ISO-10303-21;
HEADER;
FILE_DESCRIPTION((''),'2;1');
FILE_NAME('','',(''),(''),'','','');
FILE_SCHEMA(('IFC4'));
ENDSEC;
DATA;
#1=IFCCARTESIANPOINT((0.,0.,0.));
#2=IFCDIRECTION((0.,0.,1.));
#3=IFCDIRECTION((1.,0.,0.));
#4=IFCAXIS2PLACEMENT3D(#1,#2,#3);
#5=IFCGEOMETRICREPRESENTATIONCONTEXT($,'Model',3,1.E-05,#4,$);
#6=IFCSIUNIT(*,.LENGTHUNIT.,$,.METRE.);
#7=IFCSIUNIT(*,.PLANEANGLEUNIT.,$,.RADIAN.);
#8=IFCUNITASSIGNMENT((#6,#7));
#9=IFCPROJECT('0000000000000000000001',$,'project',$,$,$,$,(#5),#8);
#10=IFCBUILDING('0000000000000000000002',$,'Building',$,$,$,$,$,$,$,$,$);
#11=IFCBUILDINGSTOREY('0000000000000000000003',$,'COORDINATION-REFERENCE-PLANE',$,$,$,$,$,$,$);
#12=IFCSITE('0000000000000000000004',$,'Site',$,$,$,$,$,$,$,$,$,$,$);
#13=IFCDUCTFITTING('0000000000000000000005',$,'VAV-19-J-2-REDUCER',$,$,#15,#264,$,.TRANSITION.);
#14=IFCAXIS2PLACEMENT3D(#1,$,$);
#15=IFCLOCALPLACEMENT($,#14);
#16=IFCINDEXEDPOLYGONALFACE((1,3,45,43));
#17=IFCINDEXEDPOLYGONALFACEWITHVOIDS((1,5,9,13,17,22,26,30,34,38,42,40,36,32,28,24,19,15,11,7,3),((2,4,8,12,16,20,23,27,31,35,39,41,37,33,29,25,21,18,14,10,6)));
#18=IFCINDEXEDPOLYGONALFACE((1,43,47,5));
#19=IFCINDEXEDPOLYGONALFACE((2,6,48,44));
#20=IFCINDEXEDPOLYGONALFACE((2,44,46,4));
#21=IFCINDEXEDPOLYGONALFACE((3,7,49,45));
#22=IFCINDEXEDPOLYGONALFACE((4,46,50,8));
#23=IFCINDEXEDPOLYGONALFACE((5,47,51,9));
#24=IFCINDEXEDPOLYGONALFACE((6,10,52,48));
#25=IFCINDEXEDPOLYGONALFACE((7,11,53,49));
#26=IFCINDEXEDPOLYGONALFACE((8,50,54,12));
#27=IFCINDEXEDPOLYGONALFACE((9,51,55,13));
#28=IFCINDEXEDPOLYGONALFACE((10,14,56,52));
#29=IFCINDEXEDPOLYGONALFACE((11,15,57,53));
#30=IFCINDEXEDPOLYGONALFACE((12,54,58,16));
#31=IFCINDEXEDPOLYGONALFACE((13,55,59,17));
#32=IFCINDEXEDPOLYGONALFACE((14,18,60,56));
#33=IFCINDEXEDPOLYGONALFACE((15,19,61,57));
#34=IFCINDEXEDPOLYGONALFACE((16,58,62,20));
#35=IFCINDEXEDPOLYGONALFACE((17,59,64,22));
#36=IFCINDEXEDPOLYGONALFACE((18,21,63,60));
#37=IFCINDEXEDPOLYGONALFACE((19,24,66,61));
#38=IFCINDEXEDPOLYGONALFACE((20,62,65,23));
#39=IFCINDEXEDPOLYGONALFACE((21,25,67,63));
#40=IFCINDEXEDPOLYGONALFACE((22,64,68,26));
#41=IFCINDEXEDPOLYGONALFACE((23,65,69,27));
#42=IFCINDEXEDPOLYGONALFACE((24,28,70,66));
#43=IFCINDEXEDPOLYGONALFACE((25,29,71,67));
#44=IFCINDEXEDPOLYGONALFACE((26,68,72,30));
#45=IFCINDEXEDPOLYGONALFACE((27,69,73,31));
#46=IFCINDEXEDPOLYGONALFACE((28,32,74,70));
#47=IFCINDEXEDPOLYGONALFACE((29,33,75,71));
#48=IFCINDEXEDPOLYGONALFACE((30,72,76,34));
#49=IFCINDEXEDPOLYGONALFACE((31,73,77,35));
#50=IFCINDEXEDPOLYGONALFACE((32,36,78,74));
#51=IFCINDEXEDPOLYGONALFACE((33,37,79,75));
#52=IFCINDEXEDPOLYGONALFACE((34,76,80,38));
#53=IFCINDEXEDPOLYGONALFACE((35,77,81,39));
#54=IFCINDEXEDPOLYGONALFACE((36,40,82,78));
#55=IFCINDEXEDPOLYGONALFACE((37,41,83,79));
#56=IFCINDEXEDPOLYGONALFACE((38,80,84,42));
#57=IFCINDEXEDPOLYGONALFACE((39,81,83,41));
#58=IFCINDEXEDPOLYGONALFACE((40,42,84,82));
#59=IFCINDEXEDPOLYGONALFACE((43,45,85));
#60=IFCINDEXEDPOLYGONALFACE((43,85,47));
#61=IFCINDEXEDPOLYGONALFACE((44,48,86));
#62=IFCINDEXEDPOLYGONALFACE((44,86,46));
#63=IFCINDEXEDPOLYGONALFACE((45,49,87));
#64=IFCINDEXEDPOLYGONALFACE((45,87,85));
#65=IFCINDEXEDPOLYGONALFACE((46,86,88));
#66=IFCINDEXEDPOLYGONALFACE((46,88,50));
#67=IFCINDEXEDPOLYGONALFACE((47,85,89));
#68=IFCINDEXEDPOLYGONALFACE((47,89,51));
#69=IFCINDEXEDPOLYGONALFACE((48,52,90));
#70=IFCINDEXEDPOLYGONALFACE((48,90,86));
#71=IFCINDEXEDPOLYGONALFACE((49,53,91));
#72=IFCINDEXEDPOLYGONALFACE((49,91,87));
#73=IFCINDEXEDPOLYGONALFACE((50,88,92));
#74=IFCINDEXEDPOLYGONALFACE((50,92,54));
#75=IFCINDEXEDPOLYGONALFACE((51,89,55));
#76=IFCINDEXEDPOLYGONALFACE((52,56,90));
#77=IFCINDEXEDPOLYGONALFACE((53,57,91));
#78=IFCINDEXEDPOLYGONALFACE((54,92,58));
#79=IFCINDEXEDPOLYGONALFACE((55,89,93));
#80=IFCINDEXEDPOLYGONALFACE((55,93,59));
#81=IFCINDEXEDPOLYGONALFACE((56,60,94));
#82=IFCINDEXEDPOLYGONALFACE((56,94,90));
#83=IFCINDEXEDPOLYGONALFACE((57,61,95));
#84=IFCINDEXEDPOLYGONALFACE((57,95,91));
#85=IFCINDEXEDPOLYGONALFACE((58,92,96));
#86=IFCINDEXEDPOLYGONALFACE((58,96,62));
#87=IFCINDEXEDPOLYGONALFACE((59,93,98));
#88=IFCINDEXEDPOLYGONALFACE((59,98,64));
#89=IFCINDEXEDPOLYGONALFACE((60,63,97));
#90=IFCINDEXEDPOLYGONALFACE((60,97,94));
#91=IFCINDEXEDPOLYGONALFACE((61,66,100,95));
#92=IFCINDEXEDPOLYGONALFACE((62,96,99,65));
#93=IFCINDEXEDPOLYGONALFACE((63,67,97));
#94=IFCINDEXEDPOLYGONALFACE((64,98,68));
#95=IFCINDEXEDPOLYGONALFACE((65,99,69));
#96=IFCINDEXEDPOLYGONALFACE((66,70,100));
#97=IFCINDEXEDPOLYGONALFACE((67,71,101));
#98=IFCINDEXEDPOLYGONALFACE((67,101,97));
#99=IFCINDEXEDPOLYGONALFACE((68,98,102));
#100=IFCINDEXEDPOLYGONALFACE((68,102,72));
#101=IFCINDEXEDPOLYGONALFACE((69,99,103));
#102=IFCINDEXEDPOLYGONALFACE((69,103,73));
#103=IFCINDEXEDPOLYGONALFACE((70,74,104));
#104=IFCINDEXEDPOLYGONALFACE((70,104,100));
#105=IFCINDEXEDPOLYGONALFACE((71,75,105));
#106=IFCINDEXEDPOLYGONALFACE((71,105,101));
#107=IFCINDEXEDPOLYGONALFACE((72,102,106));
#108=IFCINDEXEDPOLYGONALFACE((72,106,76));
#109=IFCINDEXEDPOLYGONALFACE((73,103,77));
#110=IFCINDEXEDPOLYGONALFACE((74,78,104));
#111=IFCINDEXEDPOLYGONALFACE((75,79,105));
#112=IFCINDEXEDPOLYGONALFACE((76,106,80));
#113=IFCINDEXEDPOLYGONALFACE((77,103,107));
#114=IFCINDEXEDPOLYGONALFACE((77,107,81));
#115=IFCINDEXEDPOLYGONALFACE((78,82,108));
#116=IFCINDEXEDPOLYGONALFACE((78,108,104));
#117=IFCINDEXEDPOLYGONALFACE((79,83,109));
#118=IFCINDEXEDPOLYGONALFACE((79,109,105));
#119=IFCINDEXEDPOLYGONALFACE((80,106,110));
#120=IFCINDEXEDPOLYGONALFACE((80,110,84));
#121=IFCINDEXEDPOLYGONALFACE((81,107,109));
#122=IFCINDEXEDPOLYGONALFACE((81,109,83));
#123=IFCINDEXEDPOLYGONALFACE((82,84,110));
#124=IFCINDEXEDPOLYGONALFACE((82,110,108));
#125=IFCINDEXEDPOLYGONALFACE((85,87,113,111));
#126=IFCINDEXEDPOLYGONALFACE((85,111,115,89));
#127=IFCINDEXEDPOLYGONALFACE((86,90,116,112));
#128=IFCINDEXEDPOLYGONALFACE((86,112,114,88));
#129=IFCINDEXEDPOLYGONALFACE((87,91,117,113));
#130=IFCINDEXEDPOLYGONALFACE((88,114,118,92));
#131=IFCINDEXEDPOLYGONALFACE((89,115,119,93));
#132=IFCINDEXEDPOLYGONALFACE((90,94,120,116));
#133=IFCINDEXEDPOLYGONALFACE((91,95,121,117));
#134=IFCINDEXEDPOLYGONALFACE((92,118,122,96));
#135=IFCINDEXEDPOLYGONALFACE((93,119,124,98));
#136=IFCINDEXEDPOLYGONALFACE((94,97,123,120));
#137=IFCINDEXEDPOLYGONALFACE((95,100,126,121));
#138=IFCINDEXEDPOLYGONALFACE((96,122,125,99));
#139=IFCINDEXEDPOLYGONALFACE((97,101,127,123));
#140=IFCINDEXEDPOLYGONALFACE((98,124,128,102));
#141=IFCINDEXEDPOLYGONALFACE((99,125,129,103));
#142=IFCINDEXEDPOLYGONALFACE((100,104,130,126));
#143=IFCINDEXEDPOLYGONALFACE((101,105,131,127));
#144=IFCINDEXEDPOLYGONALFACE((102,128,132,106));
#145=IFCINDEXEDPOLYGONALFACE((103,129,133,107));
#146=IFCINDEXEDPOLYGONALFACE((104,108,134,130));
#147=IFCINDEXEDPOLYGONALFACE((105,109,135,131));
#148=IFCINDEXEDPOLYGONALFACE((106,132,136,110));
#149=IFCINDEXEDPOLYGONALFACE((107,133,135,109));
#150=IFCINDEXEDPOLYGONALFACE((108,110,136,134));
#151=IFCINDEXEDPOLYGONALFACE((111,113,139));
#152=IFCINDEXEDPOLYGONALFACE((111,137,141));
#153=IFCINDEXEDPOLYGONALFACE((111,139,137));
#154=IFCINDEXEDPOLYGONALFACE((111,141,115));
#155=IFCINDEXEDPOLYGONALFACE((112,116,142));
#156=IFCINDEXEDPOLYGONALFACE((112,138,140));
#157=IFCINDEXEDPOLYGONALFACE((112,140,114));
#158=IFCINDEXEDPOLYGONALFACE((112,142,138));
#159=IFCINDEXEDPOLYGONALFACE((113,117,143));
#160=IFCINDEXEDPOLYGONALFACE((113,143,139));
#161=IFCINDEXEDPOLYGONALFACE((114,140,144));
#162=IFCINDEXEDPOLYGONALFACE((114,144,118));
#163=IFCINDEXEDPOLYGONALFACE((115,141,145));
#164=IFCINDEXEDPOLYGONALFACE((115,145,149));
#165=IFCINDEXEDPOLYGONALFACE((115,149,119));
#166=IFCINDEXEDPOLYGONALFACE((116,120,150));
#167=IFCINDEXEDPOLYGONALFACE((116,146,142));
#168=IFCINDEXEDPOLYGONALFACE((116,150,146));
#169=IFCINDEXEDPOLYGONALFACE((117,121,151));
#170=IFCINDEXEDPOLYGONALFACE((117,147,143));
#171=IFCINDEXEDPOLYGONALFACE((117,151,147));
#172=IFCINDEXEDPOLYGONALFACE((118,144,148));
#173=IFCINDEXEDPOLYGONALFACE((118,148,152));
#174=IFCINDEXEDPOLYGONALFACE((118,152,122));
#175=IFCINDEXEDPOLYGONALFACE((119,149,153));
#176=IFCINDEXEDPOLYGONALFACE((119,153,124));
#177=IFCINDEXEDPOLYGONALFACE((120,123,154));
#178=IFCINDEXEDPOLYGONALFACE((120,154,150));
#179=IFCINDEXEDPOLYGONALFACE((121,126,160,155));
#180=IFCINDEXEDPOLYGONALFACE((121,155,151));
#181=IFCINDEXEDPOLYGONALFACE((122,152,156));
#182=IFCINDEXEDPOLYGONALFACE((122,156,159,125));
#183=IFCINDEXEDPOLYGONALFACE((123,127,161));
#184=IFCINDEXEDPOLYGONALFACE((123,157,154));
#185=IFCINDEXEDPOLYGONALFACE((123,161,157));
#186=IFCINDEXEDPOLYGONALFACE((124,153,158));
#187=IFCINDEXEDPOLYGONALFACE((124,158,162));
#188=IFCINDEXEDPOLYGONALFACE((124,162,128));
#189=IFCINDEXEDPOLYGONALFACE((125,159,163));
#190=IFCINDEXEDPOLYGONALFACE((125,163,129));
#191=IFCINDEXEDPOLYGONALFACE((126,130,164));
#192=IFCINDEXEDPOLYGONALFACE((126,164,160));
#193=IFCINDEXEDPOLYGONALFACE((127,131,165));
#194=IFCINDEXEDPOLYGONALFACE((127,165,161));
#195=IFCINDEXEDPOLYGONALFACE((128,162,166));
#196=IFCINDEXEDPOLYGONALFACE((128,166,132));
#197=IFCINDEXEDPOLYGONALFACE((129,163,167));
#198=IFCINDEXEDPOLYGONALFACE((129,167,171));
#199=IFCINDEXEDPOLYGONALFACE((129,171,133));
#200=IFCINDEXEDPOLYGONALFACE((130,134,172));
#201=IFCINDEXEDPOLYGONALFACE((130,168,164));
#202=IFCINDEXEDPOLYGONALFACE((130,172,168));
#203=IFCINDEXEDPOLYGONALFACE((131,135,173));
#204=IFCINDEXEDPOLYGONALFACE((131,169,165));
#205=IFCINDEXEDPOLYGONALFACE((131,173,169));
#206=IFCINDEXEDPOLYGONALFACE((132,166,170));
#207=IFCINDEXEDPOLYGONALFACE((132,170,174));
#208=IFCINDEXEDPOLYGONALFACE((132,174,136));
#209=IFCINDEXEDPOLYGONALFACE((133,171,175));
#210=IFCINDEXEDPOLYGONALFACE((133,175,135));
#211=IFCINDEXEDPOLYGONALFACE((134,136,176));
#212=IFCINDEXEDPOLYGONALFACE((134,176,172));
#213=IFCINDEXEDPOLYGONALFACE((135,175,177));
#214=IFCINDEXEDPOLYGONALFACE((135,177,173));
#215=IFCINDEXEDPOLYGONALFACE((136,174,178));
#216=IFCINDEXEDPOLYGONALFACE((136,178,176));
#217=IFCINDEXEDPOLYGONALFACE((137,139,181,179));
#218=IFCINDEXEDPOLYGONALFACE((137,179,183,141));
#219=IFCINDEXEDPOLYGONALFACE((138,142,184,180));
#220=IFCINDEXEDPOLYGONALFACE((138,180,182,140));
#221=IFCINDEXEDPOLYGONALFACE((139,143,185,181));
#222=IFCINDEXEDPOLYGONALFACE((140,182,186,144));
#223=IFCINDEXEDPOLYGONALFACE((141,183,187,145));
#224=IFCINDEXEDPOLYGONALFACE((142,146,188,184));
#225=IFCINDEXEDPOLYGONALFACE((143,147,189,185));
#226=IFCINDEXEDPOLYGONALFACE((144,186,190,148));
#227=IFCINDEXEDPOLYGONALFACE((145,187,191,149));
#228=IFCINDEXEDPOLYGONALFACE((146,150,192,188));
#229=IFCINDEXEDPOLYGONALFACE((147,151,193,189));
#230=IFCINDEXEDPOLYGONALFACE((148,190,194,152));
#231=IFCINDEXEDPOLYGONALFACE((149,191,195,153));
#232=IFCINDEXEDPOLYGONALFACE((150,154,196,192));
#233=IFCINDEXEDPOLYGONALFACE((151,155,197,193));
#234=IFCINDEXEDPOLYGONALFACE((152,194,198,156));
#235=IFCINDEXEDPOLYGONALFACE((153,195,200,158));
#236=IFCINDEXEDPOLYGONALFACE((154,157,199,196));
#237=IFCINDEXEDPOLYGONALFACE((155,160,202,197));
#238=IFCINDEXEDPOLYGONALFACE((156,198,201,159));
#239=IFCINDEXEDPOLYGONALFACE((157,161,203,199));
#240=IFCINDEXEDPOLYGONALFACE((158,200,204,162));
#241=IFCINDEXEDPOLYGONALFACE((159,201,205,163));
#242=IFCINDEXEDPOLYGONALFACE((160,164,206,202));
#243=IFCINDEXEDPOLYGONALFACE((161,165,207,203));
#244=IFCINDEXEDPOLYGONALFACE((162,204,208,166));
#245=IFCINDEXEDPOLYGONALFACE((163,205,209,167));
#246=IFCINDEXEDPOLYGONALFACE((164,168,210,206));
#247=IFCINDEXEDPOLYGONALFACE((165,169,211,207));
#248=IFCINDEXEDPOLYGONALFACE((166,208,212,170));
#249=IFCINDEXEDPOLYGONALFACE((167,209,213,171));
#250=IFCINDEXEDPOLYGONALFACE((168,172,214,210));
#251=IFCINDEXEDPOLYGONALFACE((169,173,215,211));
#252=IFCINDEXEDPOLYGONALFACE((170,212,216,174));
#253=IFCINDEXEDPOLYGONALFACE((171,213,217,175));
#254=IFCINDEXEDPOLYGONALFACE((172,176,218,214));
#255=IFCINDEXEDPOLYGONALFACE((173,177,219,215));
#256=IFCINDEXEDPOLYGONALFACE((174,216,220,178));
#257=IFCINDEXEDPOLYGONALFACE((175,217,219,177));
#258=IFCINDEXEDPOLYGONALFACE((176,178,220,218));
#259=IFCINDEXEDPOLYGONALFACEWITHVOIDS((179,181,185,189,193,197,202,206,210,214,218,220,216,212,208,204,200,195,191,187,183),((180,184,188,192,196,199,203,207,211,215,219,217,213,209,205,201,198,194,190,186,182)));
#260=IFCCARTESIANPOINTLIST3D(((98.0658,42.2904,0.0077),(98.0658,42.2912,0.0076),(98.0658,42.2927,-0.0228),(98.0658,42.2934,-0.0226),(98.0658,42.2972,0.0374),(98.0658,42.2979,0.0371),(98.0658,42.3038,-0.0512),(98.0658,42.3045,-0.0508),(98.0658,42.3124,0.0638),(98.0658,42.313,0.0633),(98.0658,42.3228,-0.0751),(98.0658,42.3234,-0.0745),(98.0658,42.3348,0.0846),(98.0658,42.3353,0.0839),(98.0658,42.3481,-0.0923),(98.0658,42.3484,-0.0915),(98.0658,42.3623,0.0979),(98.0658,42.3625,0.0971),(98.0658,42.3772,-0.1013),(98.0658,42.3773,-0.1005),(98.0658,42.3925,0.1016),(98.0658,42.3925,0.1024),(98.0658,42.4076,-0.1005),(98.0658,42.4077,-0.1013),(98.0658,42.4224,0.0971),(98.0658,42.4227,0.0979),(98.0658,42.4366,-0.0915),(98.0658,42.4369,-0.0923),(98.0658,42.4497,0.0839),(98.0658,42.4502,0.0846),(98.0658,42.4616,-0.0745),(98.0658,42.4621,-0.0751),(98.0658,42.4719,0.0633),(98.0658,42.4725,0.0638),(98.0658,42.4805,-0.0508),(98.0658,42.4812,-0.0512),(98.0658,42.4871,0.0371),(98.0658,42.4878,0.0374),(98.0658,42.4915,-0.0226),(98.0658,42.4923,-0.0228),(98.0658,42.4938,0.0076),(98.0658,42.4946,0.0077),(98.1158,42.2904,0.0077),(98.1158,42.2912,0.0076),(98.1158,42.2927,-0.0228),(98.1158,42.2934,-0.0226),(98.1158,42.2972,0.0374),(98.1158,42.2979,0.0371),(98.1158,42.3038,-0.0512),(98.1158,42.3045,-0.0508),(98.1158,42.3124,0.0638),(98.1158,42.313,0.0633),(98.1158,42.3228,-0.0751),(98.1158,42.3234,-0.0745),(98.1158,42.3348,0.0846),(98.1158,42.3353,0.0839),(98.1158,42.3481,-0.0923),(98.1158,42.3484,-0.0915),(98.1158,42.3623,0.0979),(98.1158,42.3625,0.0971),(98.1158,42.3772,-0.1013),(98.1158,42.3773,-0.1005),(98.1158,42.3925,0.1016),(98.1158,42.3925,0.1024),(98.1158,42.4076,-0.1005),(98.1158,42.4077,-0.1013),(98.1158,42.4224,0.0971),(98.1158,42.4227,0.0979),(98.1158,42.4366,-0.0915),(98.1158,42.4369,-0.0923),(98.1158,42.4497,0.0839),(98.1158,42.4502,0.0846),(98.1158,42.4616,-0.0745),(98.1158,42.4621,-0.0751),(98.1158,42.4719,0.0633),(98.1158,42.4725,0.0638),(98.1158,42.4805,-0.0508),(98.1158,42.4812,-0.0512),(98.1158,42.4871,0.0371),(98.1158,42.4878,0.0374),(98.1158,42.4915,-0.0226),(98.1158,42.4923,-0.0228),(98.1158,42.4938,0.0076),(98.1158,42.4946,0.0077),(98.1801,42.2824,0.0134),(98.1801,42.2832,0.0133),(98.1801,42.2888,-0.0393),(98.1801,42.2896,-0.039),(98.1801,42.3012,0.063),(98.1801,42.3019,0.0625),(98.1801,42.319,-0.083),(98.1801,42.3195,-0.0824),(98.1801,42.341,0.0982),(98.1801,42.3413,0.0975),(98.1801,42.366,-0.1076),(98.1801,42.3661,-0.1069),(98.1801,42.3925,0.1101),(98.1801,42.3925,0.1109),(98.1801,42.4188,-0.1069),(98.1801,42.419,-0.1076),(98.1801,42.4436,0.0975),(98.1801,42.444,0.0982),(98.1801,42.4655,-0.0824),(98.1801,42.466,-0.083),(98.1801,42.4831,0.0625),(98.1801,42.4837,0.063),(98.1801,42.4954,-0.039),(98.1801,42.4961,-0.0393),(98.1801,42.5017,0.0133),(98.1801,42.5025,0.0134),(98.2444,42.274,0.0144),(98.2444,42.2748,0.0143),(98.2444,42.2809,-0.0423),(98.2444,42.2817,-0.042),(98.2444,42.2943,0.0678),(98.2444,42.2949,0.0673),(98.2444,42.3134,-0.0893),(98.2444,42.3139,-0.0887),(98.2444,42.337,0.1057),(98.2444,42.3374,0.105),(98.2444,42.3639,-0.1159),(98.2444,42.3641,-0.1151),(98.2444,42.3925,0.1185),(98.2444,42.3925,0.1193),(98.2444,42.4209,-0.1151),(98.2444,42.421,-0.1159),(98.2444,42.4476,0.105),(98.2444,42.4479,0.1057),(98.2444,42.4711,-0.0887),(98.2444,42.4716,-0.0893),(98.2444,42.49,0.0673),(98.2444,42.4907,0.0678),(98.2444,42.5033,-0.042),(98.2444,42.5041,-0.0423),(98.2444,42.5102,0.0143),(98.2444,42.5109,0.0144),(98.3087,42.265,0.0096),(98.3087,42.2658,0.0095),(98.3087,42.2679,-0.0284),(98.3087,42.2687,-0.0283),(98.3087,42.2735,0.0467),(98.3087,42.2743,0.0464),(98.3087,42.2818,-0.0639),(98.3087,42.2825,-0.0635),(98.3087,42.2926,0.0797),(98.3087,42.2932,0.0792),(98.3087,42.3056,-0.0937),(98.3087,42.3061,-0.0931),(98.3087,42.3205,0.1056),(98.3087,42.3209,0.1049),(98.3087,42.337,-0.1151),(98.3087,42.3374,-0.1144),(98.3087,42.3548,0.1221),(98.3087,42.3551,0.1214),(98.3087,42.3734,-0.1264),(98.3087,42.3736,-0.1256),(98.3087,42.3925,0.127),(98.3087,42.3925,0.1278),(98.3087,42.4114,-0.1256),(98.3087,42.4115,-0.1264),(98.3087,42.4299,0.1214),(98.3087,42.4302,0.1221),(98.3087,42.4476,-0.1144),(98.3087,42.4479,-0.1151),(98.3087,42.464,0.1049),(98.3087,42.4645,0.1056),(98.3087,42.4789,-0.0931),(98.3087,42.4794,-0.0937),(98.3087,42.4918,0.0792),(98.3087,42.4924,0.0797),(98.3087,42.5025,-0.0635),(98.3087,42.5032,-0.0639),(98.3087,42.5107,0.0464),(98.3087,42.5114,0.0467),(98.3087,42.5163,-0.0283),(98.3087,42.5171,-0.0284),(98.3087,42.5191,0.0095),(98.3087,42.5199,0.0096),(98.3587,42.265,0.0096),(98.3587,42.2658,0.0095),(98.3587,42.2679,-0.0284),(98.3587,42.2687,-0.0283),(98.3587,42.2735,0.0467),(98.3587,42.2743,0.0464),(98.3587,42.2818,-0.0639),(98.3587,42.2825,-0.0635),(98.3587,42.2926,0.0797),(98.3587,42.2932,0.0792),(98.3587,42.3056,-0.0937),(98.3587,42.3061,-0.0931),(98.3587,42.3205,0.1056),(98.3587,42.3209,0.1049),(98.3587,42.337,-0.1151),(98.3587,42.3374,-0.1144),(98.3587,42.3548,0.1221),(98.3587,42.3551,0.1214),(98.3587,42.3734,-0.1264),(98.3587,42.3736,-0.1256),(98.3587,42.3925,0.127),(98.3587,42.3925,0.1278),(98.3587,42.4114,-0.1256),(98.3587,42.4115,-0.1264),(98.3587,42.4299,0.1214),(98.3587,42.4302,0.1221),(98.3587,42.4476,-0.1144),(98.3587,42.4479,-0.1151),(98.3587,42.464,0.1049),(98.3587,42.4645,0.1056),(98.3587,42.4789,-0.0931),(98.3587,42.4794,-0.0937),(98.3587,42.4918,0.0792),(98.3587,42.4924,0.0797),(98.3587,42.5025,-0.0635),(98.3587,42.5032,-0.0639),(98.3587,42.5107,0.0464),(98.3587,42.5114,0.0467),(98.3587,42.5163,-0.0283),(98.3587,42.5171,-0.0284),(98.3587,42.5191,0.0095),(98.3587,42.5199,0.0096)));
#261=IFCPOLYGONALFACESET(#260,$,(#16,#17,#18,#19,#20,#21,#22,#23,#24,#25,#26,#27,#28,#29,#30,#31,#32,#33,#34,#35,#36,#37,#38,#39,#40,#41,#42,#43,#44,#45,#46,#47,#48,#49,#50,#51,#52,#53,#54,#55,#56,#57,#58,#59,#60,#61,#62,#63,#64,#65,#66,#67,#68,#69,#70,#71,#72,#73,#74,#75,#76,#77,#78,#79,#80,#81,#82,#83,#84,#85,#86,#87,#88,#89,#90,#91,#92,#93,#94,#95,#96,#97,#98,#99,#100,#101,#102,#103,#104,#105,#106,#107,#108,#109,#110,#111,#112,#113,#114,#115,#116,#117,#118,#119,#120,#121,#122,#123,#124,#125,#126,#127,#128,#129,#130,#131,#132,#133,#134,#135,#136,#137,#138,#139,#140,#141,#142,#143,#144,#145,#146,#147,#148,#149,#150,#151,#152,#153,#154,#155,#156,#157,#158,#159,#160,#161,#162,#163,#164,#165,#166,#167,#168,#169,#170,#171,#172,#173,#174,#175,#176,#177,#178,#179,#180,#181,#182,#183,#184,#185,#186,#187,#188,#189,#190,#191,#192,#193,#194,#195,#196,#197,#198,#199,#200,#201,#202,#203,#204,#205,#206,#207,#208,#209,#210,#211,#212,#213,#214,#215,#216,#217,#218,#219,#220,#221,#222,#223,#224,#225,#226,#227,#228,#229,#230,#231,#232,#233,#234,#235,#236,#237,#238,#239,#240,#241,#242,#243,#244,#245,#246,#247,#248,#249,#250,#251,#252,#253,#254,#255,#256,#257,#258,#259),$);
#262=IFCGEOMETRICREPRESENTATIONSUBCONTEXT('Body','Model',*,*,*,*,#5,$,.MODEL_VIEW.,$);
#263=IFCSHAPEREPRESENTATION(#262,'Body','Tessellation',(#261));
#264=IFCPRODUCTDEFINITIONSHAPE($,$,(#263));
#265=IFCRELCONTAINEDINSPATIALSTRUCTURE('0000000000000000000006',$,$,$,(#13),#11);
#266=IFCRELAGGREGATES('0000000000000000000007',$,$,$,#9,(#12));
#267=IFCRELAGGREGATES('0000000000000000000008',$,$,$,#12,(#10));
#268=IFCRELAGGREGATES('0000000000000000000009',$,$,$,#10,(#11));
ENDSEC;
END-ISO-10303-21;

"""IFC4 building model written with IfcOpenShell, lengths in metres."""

from ifc_helpers import new_model, entity, si_unit, frame, origin_with_axes, place, context, subcontext, project, spatial, element, save


model = new_model("IFC4")

# Units and contexts
model_context_1 = context("Model", 3, precision=1e-05, world=origin_with_axes())
body_context_1 = subcontext(model_context_1, "Body", "Model", "MODEL_VIEW")
ifc_project = project(units=[si_unit("LENGTHUNIT", "METRE"), si_unit("PLANEANGLEUNIT", "RADIAN")], contexts=[model_context_1])

# Site, building, storey
site = spatial("IfcSite", under=ifc_project, Name="Site")
building = spatial("IfcBuilding", under=site, Name="Building")
storey = spatial("IfcBuildingStorey", under=building, Name="COORDINATION-REFERENCE-PLANE")

# Duct fitting
for number, where, z_axis, x_axis, name in (
    (1, (98.3587, 42.3925, 0.0), (0.0, -1.0, 0.0), (0.0, 0.0, 1.0), "VAV-19-J-2-REDUCER"),
):
    element("IfcDuctFitting", number, at=place(None, frame(where, z_axis=z_axis, x_axis=x_axis)), inside=storey, Name=name, PredefinedType="TRANSITION", context=body_context_1, shape_type="SweptSolid", body=[
        entity("IfcRevolvedAreaSolid", entity("IfcArbitraryClosedProfileDef", "AREA", None, entity("IfcPolyline", [entity("IfcCartesianPoint", [0.1278, 0.0]), entity("IfcCartesianPoint", [0.1278, 0.05]), entity("IfcCartesianPoint", [0.1024, 0.2429]), entity("IfcCartesianPoint", [0.1024, 0.2929]), entity("IfcCartesianPoint", [0.1016, 0.2929]), entity("IfcCartesianPoint", [0.1016, 0.2429]), entity("IfcCartesianPoint", [0.127, 0.05]), entity("IfcCartesianPoint", [0.127, 0.0]), entity("IfcCartesianPoint", [0.1278, 0.0])])), entity("IfcAxis2Placement3D", entity("IfcCartesianPoint", [0.0, 0.0, 0.0])), entity("IfcAxis1Placement", entity("IfcCartesianPoint", [0.0, 0.0, 0.0]), entity("IfcDirection", [0.0, 1.0, 0.0])), 6.283185),
    ])

save(model, "model.ifc")
